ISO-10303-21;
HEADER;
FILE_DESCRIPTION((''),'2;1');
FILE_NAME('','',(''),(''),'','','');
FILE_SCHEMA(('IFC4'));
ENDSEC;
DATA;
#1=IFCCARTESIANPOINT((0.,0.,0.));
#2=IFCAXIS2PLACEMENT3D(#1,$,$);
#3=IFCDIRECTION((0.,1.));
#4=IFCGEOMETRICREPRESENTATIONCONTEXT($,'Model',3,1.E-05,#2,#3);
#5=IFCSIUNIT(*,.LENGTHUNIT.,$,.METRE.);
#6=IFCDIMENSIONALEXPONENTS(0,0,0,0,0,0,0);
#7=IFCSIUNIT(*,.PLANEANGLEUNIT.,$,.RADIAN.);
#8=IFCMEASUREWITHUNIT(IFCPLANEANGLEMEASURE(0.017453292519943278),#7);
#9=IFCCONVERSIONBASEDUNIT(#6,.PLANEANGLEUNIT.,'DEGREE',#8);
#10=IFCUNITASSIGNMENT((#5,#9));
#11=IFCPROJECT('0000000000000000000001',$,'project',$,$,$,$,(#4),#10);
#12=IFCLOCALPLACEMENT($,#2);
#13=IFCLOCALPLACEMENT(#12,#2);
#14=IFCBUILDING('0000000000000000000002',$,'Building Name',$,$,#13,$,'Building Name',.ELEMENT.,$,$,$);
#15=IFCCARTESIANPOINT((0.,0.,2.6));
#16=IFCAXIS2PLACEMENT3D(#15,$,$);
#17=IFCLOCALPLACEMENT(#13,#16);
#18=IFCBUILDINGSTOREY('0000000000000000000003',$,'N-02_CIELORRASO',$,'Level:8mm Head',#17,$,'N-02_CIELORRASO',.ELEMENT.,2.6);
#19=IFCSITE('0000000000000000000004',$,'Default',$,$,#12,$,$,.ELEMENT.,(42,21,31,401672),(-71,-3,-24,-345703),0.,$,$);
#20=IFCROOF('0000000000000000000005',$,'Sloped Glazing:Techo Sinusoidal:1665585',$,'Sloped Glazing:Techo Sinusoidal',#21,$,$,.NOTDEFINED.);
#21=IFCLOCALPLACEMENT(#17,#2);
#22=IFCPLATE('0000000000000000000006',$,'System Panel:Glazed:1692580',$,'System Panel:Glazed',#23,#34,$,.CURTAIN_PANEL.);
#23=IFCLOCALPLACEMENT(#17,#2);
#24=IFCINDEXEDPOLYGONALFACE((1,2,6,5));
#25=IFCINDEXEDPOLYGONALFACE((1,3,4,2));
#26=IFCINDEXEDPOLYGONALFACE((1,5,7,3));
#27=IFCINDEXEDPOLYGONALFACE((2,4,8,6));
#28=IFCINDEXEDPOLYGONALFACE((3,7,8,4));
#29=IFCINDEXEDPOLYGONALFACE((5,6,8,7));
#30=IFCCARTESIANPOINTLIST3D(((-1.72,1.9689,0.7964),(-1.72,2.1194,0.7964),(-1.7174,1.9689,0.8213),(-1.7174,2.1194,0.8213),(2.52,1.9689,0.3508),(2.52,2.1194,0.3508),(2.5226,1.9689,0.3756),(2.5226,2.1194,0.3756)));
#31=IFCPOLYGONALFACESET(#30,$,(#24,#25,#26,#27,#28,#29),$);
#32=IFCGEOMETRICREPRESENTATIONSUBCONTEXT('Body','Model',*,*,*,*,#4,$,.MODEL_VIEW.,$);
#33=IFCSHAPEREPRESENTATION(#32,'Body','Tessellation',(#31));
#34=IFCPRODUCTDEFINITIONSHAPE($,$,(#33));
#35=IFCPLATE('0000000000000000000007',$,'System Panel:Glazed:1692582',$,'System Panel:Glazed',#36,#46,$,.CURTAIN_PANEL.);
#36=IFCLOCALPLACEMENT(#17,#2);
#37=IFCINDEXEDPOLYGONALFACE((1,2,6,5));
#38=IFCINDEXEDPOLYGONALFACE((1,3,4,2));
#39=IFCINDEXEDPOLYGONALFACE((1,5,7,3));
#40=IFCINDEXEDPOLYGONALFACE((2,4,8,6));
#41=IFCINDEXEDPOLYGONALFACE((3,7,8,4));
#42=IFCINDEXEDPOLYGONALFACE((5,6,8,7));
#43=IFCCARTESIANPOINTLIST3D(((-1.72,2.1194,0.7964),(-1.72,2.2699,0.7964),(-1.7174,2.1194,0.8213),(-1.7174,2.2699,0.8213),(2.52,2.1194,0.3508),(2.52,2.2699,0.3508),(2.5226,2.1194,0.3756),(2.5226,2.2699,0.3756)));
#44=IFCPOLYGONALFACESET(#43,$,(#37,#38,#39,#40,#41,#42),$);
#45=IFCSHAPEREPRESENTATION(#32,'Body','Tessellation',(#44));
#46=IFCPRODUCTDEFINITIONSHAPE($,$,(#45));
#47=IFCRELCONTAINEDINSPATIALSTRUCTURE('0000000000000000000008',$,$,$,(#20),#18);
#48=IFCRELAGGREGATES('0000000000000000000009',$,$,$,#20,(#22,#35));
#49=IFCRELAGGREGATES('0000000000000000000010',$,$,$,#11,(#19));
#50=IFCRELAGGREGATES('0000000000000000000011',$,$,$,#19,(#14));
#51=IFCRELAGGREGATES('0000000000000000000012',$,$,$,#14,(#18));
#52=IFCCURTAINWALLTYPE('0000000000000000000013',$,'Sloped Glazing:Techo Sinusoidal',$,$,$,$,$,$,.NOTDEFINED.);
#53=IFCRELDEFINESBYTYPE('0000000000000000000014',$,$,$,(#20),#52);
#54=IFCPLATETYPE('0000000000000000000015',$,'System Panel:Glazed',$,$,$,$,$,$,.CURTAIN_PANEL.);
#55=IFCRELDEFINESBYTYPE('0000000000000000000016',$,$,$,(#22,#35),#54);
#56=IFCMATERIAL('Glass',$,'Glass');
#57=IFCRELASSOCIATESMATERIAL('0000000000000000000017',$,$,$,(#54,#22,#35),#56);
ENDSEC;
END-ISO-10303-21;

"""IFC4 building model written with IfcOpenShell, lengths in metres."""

from ifc_helpers import new_model, entity, si_unit, converted_unit, direction, frame, origin, place, context, subcontext, project, spatial, indexed_curve, outline, extrude, source, transform, mapped, material, type_object, type_shapes, element, aggregate, save


model = new_model("IFC4")

# Units and contexts
model_context = context("Model", 3, precision=1e-05, world=origin(), true_north=direction((0.0, 1.0)))
body_context = subcontext(model_context, "Body", "Model", "MODEL_VIEW")
ifc_project = project(units=[si_unit("LENGTHUNIT", "METRE"), converted_unit("PLANEANGLEUNIT", "DEGREE", entity("IfcPlaneAngleMeasure", 0.017453292519943278), si_unit("PLANEANGLEUNIT", "RADIAN"), dimensions=[0, 0, 0, 0, 0, 0, 0])], contexts=[model_context])

# Site, building, storey
site_placement = place(None, origin())
site = spatial("IfcSite", under=ifc_project, at=site_placement, Name="Default", CompositionType="ELEMENT", RefLatitude=(42, 21, 31, 401672), RefLongitude=(-71, -3, -24, -345703), RefElevation=0.0)
building_placement = place(site_placement, origin())
building = spatial("IfcBuilding", under=site, at=building_placement, Name="Building Name", LongName="Building Name", CompositionType="ELEMENT")
storey_placement = place(building_placement, frame((0.0, 0.0, 2.6)))
storey = spatial("IfcBuildingStorey", under=building, at=storey_placement, Name="N-02_CIELORRASO", ObjectType="Level:8mm Head", LongName="N-02_CIELORRASO", CompositionType="ELEMENT", Elevation=2.6)

# Roof, plates
curtain_wall_type = type_object("IfcCurtainWallType", Name="Sloped Glazing:Techo Sinusoidal", PredefinedType="NOTDEFINED")
roof_placement = place(storey_placement, frame((0.0, 0.0, -2.6)))
roof = element("IfcRoof", 1, at=roof_placement, inside=storey, type_object=curtain_wall_type, Name="Sloped Glazing:Techo Sinusoidal:1665585", ObjectType="Sloped Glazing:Techo Sinusoidal", PredefinedType="NOTDEFINED")
ifc_material_1 = material(Name="Glass", Category="Glass")
plate_type = type_object("IfcPlateType", Name="System Panel:Glazed", PredefinedType="CURTAIN_PANEL", material=ifc_material_1)
shared_shape_1 = source(origin(), body_context, "Body", "SweptSolid", [
    extrude(outline(indexed_curve([(-0.0125, -0.0752), (0.0125, -0.0752), (0.0125, 0.0752), (-0.0125, 0.0752), (-0.0125, -0.0752)], self_intersect=False)), frame((0.0, 0.037, 0.0), z_axis=(0.0, 0.0, 1.0), x_axis=(0.0, 1.0, 0.0)), (0.0, 0.0, 1.0), 4.2634),
])
type_shapes(plate_type, [shared_shape_1])
plate_1_placement = place(roof_placement, frame((2.5252, 2.0441, 3.0), z_axis=(-0.994522, 0.0, 0.104528), x_axis=(0.0, 1.0, 0.0)))
plate_1 = element("IfcPlate", 2, at=plate_1_placement, type_object=plate_type, material=ifc_material_1, Name="System Panel:Glazed:1692580", ObjectType="System Panel:Glazed", PredefinedType="CURTAIN_PANEL", context=body_context, shape_type="MappedRepresentation", body=[
    mapped(shared_shape_1, transform((0.0, 0.0, 0.0), scale=1.0)),
])
plate_2_placement = place(roof_placement, frame((2.5252, 2.1946, 3.0), z_axis=(-0.994522, 0.0, 0.104528), x_axis=(0.0, 1.0, 0.0)))
plate_2 = element("IfcPlate", 3, at=plate_2_placement, type_object=plate_type, material=ifc_material_1, Name="System Panel:Glazed:1692582", ObjectType="System Panel:Glazed", PredefinedType="CURTAIN_PANEL", context=body_context, shape_type="MappedRepresentation", body=[
    mapped(shared_shape_1, transform((0.0, 0.0, 0.0), scale=1.0)),
])
aggregate(roof, [plate_1, plate_2])

save(model, "model.ifc")
